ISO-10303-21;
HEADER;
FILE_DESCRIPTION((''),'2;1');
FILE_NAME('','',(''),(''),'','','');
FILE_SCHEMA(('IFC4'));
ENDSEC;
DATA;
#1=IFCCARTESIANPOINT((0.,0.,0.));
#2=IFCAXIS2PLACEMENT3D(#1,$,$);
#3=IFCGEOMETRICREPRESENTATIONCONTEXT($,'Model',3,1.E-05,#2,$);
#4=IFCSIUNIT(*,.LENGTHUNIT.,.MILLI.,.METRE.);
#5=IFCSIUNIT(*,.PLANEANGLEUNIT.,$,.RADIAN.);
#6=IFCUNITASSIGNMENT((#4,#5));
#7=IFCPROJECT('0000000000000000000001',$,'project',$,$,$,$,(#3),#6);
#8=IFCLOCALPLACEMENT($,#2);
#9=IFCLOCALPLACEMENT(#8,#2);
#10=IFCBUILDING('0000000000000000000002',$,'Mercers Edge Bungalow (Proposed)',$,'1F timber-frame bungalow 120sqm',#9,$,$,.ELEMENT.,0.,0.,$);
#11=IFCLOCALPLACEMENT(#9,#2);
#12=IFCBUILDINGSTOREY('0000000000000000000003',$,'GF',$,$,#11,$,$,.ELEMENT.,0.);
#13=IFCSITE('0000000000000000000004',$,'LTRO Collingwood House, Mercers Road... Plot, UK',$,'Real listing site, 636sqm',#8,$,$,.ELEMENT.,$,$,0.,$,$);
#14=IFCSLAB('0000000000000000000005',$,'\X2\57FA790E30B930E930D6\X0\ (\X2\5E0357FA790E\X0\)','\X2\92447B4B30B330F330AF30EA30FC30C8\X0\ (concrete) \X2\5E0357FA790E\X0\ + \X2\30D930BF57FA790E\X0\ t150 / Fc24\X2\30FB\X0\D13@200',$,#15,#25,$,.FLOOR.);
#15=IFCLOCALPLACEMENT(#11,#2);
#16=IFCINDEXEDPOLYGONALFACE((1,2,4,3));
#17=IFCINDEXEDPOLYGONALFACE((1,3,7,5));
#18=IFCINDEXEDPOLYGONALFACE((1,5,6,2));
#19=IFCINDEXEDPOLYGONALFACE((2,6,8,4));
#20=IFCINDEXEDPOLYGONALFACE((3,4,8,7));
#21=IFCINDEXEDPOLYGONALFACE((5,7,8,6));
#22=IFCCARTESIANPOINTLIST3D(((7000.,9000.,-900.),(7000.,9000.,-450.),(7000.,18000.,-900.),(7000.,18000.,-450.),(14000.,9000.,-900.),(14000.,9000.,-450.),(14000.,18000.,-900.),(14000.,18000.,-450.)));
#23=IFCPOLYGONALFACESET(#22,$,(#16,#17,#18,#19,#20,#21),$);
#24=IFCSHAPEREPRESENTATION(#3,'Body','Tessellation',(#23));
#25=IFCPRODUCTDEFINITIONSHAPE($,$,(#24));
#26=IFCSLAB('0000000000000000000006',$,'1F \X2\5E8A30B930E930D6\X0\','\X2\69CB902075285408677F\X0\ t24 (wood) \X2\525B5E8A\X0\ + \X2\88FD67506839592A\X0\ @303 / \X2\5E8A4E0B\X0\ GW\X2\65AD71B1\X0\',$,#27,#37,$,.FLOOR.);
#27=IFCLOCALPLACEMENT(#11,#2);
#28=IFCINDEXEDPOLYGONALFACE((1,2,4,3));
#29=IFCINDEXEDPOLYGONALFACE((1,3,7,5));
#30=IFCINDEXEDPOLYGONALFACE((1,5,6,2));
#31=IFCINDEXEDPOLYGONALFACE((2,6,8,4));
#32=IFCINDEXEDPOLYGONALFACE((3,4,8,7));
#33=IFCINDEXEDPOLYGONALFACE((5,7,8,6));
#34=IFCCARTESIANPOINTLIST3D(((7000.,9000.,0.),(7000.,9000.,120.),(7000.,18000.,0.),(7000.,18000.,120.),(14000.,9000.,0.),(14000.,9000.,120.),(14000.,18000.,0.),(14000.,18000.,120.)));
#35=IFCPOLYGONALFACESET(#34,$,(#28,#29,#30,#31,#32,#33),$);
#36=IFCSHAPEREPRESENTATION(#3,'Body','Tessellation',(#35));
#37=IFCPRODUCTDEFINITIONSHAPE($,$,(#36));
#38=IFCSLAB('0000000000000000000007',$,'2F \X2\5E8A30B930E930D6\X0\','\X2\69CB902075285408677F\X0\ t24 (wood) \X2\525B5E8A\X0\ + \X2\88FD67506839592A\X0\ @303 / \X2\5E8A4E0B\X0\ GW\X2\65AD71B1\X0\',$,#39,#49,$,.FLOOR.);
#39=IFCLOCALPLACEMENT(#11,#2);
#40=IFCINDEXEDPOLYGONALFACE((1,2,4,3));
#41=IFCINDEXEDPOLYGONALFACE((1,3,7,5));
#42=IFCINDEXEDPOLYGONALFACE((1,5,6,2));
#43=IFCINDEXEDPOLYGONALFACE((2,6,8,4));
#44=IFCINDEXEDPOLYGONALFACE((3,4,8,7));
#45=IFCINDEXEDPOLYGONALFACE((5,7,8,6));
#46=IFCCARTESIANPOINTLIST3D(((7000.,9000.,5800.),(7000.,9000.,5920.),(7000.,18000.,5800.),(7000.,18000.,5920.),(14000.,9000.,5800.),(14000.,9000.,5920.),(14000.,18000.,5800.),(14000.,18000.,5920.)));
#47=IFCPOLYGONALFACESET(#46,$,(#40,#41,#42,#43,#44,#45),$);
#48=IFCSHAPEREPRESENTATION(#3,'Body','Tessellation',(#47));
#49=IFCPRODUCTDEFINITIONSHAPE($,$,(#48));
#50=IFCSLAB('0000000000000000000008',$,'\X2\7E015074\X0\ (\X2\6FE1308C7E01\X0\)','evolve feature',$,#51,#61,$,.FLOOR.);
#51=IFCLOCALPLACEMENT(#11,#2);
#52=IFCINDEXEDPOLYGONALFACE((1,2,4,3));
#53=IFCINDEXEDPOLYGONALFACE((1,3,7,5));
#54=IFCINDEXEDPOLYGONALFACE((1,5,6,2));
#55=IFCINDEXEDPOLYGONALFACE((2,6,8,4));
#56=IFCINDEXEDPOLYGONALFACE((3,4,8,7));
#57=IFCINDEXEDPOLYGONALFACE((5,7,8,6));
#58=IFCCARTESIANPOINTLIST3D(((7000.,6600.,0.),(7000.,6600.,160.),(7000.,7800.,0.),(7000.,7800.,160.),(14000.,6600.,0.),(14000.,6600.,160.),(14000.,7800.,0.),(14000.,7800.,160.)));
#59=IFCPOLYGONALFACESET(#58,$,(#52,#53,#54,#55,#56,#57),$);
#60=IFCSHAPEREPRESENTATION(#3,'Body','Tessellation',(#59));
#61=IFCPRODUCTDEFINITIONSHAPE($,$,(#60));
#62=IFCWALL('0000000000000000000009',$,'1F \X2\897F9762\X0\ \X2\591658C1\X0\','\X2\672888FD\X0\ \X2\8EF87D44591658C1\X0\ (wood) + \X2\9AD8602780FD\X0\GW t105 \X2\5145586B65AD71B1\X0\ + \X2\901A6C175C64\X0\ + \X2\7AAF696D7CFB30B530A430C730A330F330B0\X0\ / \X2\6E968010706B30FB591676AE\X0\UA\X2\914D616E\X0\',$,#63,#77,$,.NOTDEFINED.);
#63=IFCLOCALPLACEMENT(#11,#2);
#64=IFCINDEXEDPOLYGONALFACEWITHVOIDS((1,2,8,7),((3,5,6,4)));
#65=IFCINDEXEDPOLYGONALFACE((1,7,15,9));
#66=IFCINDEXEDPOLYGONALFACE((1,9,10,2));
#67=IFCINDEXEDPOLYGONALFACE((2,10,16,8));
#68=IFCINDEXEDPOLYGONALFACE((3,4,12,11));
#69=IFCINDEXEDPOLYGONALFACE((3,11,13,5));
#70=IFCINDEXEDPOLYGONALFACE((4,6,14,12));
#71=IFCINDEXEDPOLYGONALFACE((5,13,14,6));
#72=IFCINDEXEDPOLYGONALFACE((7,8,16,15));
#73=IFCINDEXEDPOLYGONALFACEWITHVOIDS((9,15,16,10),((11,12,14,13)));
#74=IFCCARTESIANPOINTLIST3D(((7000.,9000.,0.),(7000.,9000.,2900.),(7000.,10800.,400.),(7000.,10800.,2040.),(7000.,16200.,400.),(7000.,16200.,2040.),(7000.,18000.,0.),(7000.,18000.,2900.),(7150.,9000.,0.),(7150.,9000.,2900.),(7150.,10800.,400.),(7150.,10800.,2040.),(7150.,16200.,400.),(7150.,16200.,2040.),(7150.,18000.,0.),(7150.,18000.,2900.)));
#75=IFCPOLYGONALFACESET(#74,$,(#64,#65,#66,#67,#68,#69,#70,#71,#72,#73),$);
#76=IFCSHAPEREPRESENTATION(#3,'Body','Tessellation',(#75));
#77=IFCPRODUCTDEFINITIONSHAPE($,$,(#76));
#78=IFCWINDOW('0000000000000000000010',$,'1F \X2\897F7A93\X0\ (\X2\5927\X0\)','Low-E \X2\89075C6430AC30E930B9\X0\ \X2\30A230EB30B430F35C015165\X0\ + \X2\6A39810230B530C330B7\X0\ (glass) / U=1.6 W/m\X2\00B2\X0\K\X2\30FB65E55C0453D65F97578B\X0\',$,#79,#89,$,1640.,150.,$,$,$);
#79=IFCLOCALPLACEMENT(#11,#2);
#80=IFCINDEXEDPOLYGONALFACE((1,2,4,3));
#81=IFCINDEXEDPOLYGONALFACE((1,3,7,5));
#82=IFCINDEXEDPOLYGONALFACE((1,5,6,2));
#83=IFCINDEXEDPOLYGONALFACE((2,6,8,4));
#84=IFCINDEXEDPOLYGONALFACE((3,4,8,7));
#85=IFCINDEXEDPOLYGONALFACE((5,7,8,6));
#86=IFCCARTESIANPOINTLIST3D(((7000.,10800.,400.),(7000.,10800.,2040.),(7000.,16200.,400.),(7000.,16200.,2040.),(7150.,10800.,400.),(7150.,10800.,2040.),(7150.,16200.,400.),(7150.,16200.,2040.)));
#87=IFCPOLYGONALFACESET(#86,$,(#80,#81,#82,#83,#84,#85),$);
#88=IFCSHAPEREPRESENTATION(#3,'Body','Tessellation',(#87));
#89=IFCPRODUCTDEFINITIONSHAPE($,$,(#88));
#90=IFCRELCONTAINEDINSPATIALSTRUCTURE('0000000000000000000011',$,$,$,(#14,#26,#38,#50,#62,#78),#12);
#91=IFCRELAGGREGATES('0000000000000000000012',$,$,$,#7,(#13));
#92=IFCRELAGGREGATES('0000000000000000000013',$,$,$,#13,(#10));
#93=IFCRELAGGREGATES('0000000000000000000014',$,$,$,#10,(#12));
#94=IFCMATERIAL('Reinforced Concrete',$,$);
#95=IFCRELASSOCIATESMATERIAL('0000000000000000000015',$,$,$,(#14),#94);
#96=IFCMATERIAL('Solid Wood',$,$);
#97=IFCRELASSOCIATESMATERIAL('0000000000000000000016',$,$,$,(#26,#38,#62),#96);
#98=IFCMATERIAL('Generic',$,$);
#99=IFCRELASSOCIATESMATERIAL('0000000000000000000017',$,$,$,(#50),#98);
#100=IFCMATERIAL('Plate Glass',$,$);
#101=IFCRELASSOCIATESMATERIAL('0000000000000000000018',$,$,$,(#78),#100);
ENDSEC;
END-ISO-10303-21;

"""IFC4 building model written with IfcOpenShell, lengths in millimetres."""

from ifc_helpers import new_model, si_unit, frame, frame_2d, origin, place, context, project, spatial, rectangle, extrude, material, element, fill, save


model = new_model("IFC4")

# Units and contexts
model_context = context("Model", 3, precision=1e-05, world=origin())
ifc_project = project(units=[si_unit("LENGTHUNIT", "METRE", prefix="MILLI"), si_unit("PLANEANGLEUNIT", "RADIAN")], contexts=[model_context])

# Site, building, storey
site_placement = place(None, origin())
site = spatial("IfcSite", under=ifc_project, at=site_placement, Name="LTRO Collingwood House, Mercers Road... Plot, UK", ObjectType="Real listing site, 636sqm", CompositionType="ELEMENT", RefElevation=0.0)
building_placement = place(site_placement, origin())
building = spatial("IfcBuilding", under=site, at=building_placement, Name="Mercers Edge Bungalow (Proposed)", ObjectType="1F timber-frame bungalow 120sqm", CompositionType="ELEMENT", ElevationOfRefHeight=0.0, ElevationOfTerrain=0.0)
storey_placement = place(building_placement, origin())
storey = spatial("IfcBuildingStorey", under=building, at=storey_placement, Name="GF", CompositionType="ELEMENT", Elevation=0.0)

# Slabs
ifc_material_1 = material(Name="Reinforced Concrete")
slab_1_placement = place(storey_placement, frame((3500.0, 4500.0, -450.0)))
element("IfcSlab", 1, at=slab_1_placement, inside=storey, material=ifc_material_1, Name="基礎スラブ (布基礎)", Description="鉄筋コンクリート (concrete) 布基礎 + ベタ基礎 t150 / Fc24・D13@200", PredefinedType="FLOOR", context=model_context, shape_type="SweptSolid", body=[
    extrude(rectangle(XDim=7000.0, YDim=9000.0, at=frame_2d((3500.0, 4500.0))), frame((3500.0, 4500.0, -450.0)), (0.0, 0.0, 1.0), 450.0),
])
ifc_material_2 = material(Name="Solid Wood")
slab_2_placement = place(storey_placement, frame((3500.0, 4500.0, 0.0)))
element("IfcSlab", 2, at=slab_2_placement, inside=storey, material=ifc_material_2, Name="1F 床スラブ", Description="構造用合板 t24 (wood) 剛床 + 製材根太 @303 / 床下 GW断熱", PredefinedType="FLOOR", context=model_context, shape_type="SweptSolid", body=[
    extrude(rectangle(XDim=7000.0, YDim=9000.0, at=frame_2d((3500.0, 4500.0))), frame((3500.0, 4500.0, 0.0)), (0.0, 0.0, 1.0), 120.0),
])
slab_3_placement = place(storey_placement, frame((3500.0, 4500.0, 2900.0)))
element("IfcSlab", 3, at=slab_3_placement, inside=storey, material=ifc_material_2, Name="2F 床スラブ", Description="構造用合板 t24 (wood) 剛床 + 製材根太 @303 / 床下 GW断熱", PredefinedType="FLOOR", context=model_context, shape_type="SweptSolid", body=[
    extrude(rectangle(XDim=7000.0, YDim=9000.0, at=frame_2d((3500.0, 4500.0))), frame((3500.0, 4500.0, 2900.0)), (0.0, 0.0, 1.0), 120.0),
])
ifc_material_3 = material(Name="Generic")
slab_4_placement = place(storey_placement, frame((3500.0, 3300.0, 0.0)))
element("IfcSlab", 4, at=slab_4_placement, inside=storey, material=ifc_material_3, Name="縁側 (濡れ縁)", Description="evolve feature", PredefinedType="FLOOR", context=model_context, shape_type="SweptSolid", body=[
    extrude(rectangle(XDim=7000.0, YDim=1200.0, at=frame_2d((3500.0, 600.0))), frame((3500.0, 3300.0, 0.0)), (0.0, 0.0, 1.0), 160.0),
])

# Shared definitions
ifc_material_4 = material(Name="Plate Glass")

# Wall, opening, window
wall_1_placement = place(storey_placement, frame((3500.0, 4500.0, 0.0)))
wall_1 = element("IfcWall", 5, at=wall_1_placement, inside=storey, material=ifc_material_2, Name="1F 西面 外壁", Description="木製 軸組外壁 (wood) + 高性能GW t105 充填断熱 + 通気層 + 窯業系サイディング / 準耐火・外皮UA配慮", PredefinedType="NOTDEFINED", context=model_context, shape_type="SweptSolid", body=[
    extrude(rectangle(XDim=150.0, YDim=9000.0, at=frame_2d((75.0, 4500.0))), frame((3500.0, 4500.0, 0.0)), (0.0, 0.0, 1.0), 2900.0),
])
opening_1_placement = place(storey_placement, frame((3500.0, 5400.0, 200.0)))
opening_1 = element("IfcOpeningElement", 6, at=opening_1_placement, cuts=wall_1, PredefinedType="NOTDEFINED", context=model_context, shape_type="SweptSolid", body=[
    extrude(rectangle(XDim=150.0, YDim=5400.0, at=frame_2d((75.0, 2700.0))), frame((3500.0, 5400.0, 200.0)), (0.0, 0.0, 1.0), 1640.0),
])
window_1_placement = place(storey_placement, frame((3500.0, 5400.0, 200.0)))
window_1 = element("IfcWindow", 7, at=window_1_placement, inside=storey, material=ifc_material_4, Name="1F 西窓 (大)", Description="Low-E 複層ガラス アルゴン封入 + 樹脂サッシ (glass) / U=1.6 W/m²K・日射取得型", OverallHeight=1640.0, OverallWidth=150.0, context=model_context, shape_type="SweptSolid", body=[
    extrude(rectangle(XDim=150.0, YDim=5400.0, at=frame_2d((75.0, 2700.0))), frame((3500.0, 5400.0, 200.0)), (0.0, 0.0, 1.0), 1640.0),
])
fill(opening_1, window_1)

save(model, "model.ifc")
